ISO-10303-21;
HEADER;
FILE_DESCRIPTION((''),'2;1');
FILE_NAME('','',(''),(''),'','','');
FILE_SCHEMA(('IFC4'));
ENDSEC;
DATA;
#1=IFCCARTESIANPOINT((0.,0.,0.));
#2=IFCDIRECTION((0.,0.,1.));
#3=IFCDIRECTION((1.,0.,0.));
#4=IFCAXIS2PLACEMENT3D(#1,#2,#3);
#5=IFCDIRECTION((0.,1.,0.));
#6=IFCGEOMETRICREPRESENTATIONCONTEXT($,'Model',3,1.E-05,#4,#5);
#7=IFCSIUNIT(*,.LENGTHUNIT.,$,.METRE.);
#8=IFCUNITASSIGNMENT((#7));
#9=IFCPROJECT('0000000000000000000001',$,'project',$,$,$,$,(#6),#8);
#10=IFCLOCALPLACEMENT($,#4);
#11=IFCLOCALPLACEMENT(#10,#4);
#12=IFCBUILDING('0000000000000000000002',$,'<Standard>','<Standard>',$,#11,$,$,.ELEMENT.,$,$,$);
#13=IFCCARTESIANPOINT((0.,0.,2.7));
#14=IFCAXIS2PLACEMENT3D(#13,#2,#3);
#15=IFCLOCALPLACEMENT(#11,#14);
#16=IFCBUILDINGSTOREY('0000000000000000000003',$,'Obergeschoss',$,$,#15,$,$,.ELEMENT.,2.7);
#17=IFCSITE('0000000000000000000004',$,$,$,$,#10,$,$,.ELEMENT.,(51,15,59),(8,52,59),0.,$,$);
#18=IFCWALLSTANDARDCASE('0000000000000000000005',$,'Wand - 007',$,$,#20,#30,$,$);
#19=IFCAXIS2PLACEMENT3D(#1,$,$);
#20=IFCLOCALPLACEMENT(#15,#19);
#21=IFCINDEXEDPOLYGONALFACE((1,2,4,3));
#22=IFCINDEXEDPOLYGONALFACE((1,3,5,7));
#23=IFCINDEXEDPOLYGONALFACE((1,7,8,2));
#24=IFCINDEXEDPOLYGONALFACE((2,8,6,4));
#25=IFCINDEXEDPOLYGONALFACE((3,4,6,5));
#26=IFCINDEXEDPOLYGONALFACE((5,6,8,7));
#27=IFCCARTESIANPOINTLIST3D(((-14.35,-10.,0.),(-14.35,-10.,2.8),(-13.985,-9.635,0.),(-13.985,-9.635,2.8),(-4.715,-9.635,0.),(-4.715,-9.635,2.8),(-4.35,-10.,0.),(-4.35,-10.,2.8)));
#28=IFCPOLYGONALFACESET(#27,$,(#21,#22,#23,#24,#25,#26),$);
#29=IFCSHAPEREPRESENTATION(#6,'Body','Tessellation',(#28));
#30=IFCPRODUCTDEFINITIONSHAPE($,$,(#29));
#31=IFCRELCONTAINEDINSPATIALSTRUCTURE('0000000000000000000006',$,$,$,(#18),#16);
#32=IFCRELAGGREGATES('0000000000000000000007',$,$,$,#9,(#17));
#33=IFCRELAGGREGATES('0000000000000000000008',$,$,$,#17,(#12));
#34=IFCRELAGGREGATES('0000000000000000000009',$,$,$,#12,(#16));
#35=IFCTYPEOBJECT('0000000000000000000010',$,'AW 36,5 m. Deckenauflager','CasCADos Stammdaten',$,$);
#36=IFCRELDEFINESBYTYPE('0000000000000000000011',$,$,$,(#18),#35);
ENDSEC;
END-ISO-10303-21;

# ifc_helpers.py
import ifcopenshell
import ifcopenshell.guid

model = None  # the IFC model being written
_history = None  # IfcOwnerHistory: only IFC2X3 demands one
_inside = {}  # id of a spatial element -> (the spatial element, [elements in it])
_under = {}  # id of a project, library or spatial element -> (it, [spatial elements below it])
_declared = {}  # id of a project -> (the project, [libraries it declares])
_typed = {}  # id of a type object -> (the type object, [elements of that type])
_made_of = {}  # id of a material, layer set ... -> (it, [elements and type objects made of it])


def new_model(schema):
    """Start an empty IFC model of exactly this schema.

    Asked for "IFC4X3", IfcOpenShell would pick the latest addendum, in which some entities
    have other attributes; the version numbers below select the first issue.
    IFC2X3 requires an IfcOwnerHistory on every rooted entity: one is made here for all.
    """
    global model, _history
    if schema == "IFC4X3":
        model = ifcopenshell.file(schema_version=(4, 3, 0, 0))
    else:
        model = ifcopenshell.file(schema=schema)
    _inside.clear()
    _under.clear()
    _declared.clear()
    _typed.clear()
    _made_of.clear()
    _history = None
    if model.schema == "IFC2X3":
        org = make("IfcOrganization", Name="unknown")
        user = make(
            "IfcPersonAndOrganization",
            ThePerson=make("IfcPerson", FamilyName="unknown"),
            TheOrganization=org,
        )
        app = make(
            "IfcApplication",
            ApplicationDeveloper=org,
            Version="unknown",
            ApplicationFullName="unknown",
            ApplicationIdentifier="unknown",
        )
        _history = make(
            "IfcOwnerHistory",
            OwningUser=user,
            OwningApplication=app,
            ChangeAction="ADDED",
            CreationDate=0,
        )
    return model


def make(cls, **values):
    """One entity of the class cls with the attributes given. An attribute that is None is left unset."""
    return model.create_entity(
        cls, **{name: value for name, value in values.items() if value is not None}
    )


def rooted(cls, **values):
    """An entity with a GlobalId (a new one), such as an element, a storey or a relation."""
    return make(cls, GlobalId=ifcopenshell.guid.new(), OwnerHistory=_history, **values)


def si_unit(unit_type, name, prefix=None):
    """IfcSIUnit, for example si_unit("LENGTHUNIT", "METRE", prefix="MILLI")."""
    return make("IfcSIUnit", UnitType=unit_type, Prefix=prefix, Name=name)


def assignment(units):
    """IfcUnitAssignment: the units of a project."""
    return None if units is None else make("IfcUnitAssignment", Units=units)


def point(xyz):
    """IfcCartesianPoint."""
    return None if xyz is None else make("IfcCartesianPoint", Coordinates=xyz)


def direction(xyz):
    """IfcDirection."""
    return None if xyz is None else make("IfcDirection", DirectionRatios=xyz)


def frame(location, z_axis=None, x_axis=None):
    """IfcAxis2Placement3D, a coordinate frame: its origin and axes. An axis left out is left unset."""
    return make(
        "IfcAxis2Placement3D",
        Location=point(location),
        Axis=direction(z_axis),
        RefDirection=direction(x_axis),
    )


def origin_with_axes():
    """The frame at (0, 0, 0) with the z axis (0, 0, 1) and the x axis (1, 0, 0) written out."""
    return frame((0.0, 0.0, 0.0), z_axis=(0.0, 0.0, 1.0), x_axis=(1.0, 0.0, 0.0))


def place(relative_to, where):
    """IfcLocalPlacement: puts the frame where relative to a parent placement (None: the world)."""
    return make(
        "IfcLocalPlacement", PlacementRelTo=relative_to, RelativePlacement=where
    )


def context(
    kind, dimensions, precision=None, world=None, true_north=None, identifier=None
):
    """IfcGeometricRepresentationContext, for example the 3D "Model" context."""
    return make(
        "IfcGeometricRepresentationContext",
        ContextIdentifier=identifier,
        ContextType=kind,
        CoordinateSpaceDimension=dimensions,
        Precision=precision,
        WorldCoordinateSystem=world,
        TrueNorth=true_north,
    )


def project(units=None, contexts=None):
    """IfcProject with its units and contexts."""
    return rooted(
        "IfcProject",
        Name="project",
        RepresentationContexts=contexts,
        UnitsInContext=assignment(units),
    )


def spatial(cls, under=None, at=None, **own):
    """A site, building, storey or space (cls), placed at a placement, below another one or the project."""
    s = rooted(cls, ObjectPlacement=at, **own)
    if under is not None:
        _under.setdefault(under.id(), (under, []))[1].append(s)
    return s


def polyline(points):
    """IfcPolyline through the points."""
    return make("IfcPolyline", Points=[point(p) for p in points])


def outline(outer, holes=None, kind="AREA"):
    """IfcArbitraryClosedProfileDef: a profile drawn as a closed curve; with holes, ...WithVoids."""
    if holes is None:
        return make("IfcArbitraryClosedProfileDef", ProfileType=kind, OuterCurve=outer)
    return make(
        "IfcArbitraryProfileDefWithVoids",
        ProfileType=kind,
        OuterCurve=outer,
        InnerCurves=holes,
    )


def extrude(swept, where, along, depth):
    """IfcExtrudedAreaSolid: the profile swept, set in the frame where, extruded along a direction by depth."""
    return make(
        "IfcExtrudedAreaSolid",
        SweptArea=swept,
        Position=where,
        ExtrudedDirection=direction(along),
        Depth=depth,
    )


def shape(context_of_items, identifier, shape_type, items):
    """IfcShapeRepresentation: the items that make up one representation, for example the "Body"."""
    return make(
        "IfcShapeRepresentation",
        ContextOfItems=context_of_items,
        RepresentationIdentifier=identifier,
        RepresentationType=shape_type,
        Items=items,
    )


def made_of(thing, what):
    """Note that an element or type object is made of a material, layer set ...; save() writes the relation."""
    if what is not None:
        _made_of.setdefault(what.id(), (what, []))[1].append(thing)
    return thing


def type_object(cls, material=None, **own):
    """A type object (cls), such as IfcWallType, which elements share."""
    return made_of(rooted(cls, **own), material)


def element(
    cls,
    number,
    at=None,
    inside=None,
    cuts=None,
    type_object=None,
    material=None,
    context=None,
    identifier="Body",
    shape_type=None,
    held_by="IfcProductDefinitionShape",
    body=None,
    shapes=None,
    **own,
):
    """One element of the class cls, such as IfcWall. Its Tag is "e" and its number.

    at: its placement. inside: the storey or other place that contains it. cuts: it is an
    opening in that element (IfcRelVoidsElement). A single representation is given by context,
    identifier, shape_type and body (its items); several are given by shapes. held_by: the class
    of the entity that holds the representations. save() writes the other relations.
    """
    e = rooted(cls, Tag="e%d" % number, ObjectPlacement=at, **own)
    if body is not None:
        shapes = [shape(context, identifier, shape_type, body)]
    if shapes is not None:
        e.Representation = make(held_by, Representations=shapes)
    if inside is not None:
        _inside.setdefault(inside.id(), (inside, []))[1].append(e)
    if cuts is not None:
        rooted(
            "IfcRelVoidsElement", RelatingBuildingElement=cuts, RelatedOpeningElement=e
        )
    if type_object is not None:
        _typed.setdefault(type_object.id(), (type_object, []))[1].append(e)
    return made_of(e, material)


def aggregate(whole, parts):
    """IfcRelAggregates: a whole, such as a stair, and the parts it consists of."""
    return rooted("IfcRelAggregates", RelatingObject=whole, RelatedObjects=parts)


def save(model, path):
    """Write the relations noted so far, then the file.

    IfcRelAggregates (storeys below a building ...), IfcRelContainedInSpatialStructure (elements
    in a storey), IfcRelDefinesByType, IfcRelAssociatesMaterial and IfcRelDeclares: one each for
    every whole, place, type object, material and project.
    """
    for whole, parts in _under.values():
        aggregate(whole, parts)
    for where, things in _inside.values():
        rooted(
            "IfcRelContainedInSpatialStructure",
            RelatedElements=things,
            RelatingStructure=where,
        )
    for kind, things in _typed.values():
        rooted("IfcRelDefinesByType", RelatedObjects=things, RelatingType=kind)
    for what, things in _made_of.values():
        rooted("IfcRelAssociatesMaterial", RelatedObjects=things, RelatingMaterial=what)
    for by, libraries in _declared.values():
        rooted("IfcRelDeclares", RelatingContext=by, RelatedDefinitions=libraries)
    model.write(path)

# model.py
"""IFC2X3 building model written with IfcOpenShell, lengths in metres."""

from ifc_helpers import new_model, si_unit, direction, frame, origin_with_axes, place, context, project, spatial, polyline, outline, extrude, type_object, element, save


model = new_model("IFC2X3")

# Units and contexts
model_context = context("Model", 3, precision=1e-05, world=origin_with_axes(), true_north=direction((0.0, 1.0, 0.0)))
ifc_project = project(units=[si_unit("LENGTHUNIT", "METRE")], contexts=[model_context])

# Site, building, storey
site_placement = place(None, origin_with_axes())
site = spatial("IfcSite", under=ifc_project, at=site_placement, CompositionType="ELEMENT", RefLatitude=(51, 15, 59), RefLongitude=(8, 52, 59), RefElevation=0.0)
building_placement = place(site_placement, origin_with_axes())
building = spatial("IfcBuilding", under=site, at=building_placement, Name="<Standard>", Description="<Standard>", CompositionType="ELEMENT")
storey_placement = place(building_placement, frame((0.0, 0.0, 2.7), z_axis=(0.0, 0.0, 1.0), x_axis=(1.0, 0.0, 0.0)))
storey = spatial("IfcBuildingStorey", under=building, at=storey_placement, Name="Obergeschoss", CompositionType="ELEMENT", Elevation=2.7)

# Wall
ifc_type_object_1 = type_object("IfcTypeObject", Name="AW 36,5 m. Deckenauflager", Description="CasCADos Stammdaten")
wall_1_placement = place(storey_placement, frame((-14.35, -10.0, 0.0), z_axis=(0.0, 0.0, 1.0), x_axis=(1.0, 0.0, 0.0)))
element("IfcWallStandardCase", 1, at=wall_1_placement, inside=storey, type_object=ifc_type_object_1, Name="Wand - 007", context=model_context, shape_type="SweptSolid", body=[
    extrude(outline(polyline([(0.365, 0.365), (0.0, 0.0), (10.0, 0.0), (9.635, 0.365), (0.365, 0.365)])), origin_with_axes(), (0.0, 0.0, 1.0), 2.8),
])

save(model, "model.ifc")
